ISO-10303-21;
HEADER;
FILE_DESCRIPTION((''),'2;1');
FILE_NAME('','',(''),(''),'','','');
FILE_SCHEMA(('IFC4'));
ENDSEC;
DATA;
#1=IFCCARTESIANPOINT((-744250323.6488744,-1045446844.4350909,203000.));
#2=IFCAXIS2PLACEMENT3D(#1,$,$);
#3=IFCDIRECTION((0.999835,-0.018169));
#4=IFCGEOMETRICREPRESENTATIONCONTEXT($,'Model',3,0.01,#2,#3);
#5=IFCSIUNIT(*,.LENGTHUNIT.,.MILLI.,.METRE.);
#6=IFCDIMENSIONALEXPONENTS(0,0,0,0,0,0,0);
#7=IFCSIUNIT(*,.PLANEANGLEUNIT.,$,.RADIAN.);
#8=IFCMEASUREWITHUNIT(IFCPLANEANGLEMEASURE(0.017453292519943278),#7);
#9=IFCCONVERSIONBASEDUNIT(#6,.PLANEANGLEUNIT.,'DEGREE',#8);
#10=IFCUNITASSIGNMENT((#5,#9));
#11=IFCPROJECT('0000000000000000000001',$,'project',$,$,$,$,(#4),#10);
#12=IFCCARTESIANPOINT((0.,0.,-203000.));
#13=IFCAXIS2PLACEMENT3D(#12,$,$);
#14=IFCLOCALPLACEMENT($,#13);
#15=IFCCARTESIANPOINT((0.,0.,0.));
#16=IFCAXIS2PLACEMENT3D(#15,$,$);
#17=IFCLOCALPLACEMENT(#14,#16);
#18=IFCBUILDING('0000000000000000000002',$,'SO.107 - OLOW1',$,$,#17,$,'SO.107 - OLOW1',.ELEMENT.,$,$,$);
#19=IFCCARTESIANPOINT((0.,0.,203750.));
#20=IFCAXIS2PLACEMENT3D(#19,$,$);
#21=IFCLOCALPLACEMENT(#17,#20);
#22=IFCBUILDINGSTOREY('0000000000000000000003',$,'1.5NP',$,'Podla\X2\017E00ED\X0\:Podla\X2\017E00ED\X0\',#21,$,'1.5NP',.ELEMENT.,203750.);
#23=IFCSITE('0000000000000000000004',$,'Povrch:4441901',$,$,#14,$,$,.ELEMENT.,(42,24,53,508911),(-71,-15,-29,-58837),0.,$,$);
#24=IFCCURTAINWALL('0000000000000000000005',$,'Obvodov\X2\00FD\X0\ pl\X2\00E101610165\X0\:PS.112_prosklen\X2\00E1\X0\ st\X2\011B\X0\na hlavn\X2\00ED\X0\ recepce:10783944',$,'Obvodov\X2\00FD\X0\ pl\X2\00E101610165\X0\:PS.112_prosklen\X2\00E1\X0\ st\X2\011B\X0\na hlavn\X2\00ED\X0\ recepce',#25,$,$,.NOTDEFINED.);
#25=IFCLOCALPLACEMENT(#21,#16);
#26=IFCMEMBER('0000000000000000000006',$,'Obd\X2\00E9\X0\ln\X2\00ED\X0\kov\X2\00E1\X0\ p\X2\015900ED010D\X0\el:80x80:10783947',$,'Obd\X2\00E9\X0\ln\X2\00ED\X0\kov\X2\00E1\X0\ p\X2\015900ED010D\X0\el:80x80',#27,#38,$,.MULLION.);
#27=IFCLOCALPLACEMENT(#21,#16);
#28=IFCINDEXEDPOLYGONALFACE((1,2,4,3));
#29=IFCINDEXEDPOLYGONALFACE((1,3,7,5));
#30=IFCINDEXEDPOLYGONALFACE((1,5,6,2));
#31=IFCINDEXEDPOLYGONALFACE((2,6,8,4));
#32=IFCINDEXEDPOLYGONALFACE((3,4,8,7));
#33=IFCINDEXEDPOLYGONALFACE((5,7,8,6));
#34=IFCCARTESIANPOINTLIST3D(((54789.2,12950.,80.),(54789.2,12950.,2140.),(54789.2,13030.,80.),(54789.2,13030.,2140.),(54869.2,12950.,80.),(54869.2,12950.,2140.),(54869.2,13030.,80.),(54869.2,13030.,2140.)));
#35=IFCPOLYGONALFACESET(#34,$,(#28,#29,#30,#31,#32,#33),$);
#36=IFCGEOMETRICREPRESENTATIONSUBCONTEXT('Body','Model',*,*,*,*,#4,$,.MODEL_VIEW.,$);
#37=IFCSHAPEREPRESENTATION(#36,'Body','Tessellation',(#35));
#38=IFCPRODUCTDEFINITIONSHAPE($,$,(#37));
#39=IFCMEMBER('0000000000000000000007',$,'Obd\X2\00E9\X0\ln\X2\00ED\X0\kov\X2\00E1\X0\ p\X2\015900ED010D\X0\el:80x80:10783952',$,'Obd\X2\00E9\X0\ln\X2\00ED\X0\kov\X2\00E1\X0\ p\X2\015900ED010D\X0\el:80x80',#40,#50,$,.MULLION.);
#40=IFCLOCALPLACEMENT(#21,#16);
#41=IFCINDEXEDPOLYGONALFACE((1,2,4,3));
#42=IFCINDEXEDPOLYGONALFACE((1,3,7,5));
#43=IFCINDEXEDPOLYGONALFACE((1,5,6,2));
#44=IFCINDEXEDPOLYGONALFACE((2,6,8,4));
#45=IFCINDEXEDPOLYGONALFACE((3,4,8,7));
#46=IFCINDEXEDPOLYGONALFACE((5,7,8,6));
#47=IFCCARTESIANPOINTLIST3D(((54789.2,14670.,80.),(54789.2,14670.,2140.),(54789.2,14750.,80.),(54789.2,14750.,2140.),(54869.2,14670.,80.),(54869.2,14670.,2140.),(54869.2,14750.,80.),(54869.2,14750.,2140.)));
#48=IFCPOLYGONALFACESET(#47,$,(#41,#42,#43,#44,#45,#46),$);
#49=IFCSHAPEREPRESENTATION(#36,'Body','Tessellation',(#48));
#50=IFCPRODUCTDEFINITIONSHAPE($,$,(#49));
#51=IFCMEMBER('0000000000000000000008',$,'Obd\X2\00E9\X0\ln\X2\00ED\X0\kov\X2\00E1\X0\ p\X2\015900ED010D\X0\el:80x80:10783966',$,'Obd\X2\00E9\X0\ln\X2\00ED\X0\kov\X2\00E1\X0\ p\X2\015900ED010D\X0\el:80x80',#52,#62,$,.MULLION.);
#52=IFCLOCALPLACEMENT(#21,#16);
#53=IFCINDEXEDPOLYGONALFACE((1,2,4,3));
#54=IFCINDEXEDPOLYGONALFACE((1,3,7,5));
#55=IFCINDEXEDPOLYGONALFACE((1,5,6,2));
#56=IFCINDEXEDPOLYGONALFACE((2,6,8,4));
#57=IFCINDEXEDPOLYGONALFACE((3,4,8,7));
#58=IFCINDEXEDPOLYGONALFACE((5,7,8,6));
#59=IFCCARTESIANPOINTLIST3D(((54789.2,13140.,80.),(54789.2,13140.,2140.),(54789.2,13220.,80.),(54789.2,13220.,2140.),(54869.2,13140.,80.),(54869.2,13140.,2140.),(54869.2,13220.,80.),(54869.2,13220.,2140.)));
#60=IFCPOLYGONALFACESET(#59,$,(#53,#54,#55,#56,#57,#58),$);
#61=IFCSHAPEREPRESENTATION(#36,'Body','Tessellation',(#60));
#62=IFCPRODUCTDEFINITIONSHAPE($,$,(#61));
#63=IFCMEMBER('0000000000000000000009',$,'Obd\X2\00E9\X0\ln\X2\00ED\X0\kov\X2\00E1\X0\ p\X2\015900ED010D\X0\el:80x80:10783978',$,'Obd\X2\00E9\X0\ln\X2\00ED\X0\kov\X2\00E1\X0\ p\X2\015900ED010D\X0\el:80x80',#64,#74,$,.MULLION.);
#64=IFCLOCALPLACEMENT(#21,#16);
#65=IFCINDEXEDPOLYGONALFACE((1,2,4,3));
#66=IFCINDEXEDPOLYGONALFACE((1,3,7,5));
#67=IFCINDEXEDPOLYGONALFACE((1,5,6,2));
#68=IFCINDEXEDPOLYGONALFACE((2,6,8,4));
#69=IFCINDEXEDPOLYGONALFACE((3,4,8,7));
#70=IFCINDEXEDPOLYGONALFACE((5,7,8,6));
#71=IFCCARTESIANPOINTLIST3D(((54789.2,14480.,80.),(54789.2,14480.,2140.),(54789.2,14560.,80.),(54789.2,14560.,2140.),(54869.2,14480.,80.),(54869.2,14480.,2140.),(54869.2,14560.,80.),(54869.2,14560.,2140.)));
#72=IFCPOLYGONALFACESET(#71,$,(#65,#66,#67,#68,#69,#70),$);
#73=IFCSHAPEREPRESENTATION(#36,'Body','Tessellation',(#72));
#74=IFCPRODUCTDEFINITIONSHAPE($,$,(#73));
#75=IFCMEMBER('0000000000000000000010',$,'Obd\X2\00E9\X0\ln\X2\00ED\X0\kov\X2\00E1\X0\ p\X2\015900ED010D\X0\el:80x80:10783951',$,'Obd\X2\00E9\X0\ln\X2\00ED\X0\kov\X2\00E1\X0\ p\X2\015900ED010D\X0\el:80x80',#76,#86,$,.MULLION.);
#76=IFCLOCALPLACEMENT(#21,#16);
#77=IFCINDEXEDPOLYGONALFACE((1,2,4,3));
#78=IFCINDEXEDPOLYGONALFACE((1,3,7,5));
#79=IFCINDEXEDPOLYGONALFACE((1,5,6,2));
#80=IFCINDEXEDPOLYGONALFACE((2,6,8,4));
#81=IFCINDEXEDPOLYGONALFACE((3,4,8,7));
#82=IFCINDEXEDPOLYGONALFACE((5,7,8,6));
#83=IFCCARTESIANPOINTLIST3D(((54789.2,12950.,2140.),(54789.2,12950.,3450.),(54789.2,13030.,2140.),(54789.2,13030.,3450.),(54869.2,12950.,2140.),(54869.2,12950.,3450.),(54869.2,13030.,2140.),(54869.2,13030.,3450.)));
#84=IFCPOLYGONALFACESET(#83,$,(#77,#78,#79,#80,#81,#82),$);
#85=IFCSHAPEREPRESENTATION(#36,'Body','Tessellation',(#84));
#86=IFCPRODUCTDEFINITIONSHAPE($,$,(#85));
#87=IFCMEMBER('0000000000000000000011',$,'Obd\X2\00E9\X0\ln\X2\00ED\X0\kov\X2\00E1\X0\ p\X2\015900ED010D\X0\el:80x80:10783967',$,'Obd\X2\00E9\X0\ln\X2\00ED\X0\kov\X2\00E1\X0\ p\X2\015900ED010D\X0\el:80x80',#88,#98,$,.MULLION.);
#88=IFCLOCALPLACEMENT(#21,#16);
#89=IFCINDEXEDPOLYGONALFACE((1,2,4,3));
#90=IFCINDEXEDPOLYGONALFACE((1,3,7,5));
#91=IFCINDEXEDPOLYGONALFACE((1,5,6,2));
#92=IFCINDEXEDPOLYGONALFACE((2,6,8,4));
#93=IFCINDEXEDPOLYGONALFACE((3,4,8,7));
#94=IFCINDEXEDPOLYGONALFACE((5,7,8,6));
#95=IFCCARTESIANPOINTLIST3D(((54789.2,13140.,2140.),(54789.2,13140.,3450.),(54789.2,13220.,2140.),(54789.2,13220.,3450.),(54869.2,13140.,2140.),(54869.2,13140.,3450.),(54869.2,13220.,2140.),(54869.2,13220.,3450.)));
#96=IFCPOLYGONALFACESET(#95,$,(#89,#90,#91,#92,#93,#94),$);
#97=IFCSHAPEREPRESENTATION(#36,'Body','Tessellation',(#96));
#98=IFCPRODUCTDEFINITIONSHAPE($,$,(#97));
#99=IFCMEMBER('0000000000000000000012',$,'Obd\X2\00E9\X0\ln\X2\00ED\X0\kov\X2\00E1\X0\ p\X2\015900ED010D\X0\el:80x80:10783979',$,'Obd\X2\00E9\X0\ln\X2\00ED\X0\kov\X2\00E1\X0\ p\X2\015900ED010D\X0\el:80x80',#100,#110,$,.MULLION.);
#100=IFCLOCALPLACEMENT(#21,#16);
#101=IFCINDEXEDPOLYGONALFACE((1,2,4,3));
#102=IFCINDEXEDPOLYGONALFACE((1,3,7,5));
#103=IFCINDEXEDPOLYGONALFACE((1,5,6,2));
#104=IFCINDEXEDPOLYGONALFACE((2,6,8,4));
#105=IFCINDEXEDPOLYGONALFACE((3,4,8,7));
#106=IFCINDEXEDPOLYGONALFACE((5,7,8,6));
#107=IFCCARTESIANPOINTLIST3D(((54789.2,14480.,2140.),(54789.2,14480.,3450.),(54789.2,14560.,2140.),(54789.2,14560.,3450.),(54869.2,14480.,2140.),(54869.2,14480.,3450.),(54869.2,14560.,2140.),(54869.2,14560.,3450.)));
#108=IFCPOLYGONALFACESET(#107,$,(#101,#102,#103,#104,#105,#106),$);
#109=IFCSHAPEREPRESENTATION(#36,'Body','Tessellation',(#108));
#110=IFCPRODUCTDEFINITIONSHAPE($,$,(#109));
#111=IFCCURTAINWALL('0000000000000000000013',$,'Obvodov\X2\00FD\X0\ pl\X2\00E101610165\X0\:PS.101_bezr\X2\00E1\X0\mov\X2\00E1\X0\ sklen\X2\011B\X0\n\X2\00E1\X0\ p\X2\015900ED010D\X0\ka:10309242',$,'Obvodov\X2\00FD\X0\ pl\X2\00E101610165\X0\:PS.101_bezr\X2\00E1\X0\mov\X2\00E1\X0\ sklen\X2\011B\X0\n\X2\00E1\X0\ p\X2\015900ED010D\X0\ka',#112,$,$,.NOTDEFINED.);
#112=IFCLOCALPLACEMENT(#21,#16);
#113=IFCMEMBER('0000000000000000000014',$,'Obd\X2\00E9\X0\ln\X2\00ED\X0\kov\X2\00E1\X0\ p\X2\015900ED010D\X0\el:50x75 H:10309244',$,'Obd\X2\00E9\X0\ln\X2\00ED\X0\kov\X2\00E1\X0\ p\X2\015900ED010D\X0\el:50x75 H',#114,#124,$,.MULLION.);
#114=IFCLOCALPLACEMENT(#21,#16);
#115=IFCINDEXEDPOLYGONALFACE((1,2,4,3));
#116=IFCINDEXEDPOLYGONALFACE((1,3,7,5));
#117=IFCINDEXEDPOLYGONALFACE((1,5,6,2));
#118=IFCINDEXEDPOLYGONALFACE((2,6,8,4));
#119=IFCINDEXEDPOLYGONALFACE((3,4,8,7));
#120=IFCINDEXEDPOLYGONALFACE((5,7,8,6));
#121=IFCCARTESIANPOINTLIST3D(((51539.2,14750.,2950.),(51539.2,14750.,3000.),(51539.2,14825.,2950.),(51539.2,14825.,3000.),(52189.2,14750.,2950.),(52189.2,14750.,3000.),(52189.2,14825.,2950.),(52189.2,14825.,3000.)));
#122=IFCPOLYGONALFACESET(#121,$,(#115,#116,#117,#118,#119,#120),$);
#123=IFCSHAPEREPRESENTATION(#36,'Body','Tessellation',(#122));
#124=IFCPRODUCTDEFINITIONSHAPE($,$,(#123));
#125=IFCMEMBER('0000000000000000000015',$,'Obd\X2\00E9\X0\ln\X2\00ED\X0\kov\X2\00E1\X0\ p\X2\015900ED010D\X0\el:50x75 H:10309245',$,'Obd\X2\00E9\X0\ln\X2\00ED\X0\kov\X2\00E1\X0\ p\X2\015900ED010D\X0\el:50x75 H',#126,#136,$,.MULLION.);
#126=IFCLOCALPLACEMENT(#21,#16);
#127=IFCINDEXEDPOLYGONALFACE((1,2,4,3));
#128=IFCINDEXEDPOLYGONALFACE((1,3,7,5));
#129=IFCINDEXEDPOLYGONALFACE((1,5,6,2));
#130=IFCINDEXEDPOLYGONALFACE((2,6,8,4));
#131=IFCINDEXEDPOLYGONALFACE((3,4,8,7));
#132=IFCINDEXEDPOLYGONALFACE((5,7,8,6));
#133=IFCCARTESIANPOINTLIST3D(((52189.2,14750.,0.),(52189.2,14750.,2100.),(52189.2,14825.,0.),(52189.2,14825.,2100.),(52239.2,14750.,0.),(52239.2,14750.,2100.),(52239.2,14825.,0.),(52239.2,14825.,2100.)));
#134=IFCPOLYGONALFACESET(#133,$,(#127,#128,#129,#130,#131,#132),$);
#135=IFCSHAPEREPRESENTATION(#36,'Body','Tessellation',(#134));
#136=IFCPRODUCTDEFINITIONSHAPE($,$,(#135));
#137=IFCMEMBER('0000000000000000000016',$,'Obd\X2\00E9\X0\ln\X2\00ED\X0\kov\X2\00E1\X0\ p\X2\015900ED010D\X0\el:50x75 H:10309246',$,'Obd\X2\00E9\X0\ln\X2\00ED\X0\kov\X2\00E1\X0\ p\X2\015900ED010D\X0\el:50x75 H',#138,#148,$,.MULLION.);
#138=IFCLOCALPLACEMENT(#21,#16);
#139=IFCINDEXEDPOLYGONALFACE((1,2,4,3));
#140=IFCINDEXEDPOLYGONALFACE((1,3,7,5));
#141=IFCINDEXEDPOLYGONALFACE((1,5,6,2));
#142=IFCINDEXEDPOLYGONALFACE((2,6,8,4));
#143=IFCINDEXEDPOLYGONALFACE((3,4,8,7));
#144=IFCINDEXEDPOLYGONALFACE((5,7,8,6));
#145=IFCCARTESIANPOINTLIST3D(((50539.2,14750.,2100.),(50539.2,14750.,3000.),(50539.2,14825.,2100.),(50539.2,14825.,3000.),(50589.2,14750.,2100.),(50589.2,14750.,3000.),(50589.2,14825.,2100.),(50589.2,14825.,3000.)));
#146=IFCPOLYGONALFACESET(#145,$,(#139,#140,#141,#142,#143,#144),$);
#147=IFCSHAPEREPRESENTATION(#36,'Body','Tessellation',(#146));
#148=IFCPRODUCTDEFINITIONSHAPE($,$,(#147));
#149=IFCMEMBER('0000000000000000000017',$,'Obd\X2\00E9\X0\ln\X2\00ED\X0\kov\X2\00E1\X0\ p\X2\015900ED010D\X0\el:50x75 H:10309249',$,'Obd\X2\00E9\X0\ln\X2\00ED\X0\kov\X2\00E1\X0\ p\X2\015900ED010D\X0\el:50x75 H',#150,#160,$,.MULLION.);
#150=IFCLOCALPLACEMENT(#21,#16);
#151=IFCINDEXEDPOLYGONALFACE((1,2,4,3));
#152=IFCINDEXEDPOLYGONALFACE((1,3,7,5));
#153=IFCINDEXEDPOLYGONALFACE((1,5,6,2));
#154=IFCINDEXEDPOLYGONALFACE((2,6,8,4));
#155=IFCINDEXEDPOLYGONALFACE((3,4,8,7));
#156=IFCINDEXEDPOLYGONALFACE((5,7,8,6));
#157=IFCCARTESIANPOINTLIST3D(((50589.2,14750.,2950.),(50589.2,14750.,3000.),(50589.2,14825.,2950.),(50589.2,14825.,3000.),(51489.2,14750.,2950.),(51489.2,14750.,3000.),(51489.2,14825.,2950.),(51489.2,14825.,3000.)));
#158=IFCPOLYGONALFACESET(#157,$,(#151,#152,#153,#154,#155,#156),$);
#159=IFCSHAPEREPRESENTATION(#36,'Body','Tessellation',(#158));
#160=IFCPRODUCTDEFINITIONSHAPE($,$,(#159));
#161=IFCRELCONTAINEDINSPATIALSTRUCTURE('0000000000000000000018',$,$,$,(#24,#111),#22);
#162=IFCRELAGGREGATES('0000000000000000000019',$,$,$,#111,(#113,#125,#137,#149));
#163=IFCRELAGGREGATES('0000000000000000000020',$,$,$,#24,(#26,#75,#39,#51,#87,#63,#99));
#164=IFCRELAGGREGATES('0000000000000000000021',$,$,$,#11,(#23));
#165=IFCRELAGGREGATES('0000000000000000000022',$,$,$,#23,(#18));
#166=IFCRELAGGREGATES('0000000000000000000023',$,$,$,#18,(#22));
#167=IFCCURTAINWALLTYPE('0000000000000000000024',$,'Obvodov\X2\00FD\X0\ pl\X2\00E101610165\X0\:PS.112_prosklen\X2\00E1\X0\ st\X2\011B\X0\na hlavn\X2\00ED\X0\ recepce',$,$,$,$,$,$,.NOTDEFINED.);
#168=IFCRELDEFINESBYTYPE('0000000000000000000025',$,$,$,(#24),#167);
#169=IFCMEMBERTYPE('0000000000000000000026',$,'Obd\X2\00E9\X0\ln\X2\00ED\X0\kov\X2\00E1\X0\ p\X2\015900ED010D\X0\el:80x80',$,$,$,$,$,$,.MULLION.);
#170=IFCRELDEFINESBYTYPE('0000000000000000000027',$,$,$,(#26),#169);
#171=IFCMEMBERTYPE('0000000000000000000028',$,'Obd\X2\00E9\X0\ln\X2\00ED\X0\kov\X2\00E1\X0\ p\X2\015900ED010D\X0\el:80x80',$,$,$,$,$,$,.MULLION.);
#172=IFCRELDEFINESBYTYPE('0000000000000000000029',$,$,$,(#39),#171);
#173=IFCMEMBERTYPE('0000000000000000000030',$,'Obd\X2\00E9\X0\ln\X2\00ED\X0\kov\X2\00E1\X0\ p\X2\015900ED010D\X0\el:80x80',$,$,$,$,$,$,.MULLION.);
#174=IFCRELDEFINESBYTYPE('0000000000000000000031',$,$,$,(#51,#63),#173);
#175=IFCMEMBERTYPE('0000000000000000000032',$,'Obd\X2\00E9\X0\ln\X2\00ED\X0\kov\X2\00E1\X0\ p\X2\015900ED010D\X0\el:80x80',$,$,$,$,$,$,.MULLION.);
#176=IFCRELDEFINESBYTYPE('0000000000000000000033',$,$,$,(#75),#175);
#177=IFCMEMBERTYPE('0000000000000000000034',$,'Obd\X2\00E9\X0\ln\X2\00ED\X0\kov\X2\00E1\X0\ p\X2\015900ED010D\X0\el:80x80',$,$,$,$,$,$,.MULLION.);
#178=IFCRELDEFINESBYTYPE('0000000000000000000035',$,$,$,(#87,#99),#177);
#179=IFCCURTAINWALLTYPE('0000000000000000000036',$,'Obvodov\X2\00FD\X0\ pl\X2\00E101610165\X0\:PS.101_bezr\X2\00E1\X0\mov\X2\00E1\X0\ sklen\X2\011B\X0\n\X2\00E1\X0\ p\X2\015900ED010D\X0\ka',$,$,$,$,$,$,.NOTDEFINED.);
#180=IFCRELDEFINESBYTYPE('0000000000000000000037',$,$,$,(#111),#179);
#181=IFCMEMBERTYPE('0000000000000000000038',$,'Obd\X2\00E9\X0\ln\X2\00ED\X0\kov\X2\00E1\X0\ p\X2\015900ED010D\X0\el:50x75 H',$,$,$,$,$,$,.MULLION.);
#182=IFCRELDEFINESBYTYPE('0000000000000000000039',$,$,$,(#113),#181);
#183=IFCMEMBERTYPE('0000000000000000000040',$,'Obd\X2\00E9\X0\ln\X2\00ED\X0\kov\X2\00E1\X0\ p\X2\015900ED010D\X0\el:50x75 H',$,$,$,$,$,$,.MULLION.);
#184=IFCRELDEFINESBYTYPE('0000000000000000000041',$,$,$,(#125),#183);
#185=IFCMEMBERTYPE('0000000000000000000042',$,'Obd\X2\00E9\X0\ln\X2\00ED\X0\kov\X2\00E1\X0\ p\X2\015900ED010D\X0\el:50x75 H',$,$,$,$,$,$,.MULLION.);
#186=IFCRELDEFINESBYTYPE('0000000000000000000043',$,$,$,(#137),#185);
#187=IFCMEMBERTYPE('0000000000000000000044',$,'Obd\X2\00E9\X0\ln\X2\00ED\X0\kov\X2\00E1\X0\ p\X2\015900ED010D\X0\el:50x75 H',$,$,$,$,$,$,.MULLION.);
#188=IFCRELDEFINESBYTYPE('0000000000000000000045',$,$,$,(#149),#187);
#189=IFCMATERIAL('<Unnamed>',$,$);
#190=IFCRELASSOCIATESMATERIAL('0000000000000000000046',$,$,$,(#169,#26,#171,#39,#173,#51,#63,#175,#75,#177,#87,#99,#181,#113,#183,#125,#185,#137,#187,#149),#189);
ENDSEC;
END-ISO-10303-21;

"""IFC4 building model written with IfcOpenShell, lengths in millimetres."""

from ifc_helpers import new_model, entity, si_unit, converted_unit, direction, frame, origin, place, context, subcontext, project, spatial, indexed_curve, outline, extrude, source, transform, mapped, material, type_object, type_shapes, element, aggregate, save


model = new_model("IFC4")

# Units and contexts
model_context = context("Model", 3, precision=0.01, world=frame((-744250323.6488744, -1045446844.4350909, 203000.0)), true_north=direction((0.999835, -0.018169)))
body_context = subcontext(model_context, "Body", "Model", "MODEL_VIEW")
ifc_project = project(units=[si_unit("LENGTHUNIT", "METRE", prefix="MILLI"), converted_unit("PLANEANGLEUNIT", "DEGREE", entity("IfcPlaneAngleMeasure", 0.017453292519943278), si_unit("PLANEANGLEUNIT", "RADIAN"), dimensions=[0, 0, 0, 0, 0, 0, 0])], contexts=[model_context])

# Site, building, storey
site_placement = place(None, frame((0.0, 0.0, -203000.0)))
site = spatial("IfcSite", under=ifc_project, at=site_placement, Name="Povrch:4441901", CompositionType="ELEMENT", RefLatitude=(42, 24, 53, 508911), RefLongitude=(-71, -15, -29, -58837), RefElevation=0.0)
building_placement = place(site_placement, origin())
building = spatial("IfcBuilding", under=site, at=building_placement, Name="SO.107 - OLOW1", LongName="SO.107 - OLOW1", CompositionType="ELEMENT")
storey_placement = place(building_placement, frame((0.0, 0.0, 203750.0)))
storey = spatial("IfcBuildingStorey", under=building, at=storey_placement, Name="1.5NP", ObjectType="Podlaží:Podlaží", LongName="1.5NP", CompositionType="ELEMENT", Elevation=203750.0)

# Curtain walls, members
curtain_wall_type_1 = type_object("IfcCurtainWallType", Name="Obvodový plášť:PS.112_prosklená stěna hlavní recepce", PredefinedType="NOTDEFINED")
curtain_wall_1_placement = place(storey_placement, frame((0.0, 0.0, -203750.0)))
curtain_wall_1 = element("IfcCurtainWall", 1, at=curtain_wall_1_placement, inside=storey, type_object=curtain_wall_type_1, Name="Obvodový plášť:PS.112_prosklená stěna hlavní recepce:10783944", ObjectType="Obvodový plášť:PS.112_prosklená stěna hlavní recepce", PredefinedType="NOTDEFINED")
ifc_material_1 = material(Name="<Unnamed>")
member_type_1 = type_object("IfcMemberType", Name="Obdélníková příčel:80x80", PredefinedType="MULLION", material=ifc_material_1)
shared_shape_1 = source(origin(), body_context, "Body", "SweptSolid", [
    extrude(outline(indexed_curve([(-40.0, -40.0), (40.0, -40.0), (40.0, 40.0), (-40.0, 40.0), (-40.0, -40.0)], self_intersect=False)), frame((-40.0, 0.0, -2060.0), z_axis=(0.0, 0.0, 1.0), x_axis=(-1.0, 0.0, 0.0)), (0.0, 0.0, 1.0), 2060.0),
])
type_shapes(member_type_1, [shared_shape_1])
member_1_placement = place(curtain_wall_1_placement, frame((54829.2, 12950.0, 203830.0), z_axis=(0.0, 0.0, -1.0), x_axis=(0.0, -1.0, 0.0)))
member_1 = element("IfcMember", 2, at=member_1_placement, type_object=member_type_1, material=ifc_material_1, Name="Obdélníková příčel:80x80:10783947", ObjectType="Obdélníková příčel:80x80", PredefinedType="MULLION", context=body_context, shape_type="MappedRepresentation", body=[
    mapped(shared_shape_1, transform((0.0, 0.0, 0.0), scale=1.0)),
])
member_type_2 = type_object("IfcMemberType", Name="Obdélníková příčel:80x80", PredefinedType="MULLION", material=ifc_material_1)
shared_shape_2 = source(origin(), body_context, "Body", "SweptSolid", [
    extrude(outline(indexed_curve([(-40.0, -40.0), (40.0, -40.0), (40.0, 40.0), (-40.0, 40.0), (-40.0, -40.0)], self_intersect=False)), frame((-40.0, 0.0, -2060.0), z_axis=(0.0, 0.0, 1.0), x_axis=(-1.0, 0.0, 0.0)), (0.0, 0.0, 1.0), 2060.0),
])
type_shapes(member_type_2, [shared_shape_2])
member_2_placement = place(curtain_wall_1_placement, frame((54829.2, 14750.0, 205890.0), z_axis=(0.0, 0.0, 1.0), x_axis=(0.0, 1.0, 0.0)))
member_2 = element("IfcMember", 3, at=member_2_placement, type_object=member_type_2, material=ifc_material_1, Name="Obdélníková příčel:80x80:10783952", ObjectType="Obdélníková příčel:80x80", PredefinedType="MULLION", context=body_context, shape_type="MappedRepresentation", body=[
    mapped(shared_shape_2, transform((0.0, 0.0, 0.0), scale=1.0)),
])
member_type_3 = type_object("IfcMemberType", Name="Obdélníková příčel:80x80", PredefinedType="MULLION", material=ifc_material_1)
shared_shape_3 = source(origin(), body_context, "Body", "SweptSolid", [
    extrude(outline(indexed_curve([(-40.0, -40.0), (40.0, -40.0), (40.0, 40.0), (-40.0, 40.0), (-40.0, -40.0)], self_intersect=False)), frame((0.0, 0.0, -2060.0), z_axis=(0.0, 0.0, 1.0), x_axis=(-1.0, 0.0, 0.0)), (0.0, 0.0, 1.0), 2060.0),
])
type_shapes(member_type_3, [shared_shape_3])
member_3_placement = place(curtain_wall_1_placement, frame((54829.2, 13180.0, 203830.0), z_axis=(0.0, 0.0, -1.0), x_axis=(0.0, -1.0, 0.0)))
member_3 = element("IfcMember", 4, at=member_3_placement, type_object=member_type_3, material=ifc_material_1, Name="Obdélníková příčel:80x80:10783966", ObjectType="Obdélníková příčel:80x80", PredefinedType="MULLION", context=body_context, shape_type="MappedRepresentation", body=[
    mapped(shared_shape_3, transform((0.0, 0.0, 0.0), scale=1.0)),
])
member_4_placement = place(curtain_wall_1_placement, frame((54829.2, 14520.0, 203830.0), z_axis=(0.0, 0.0, -1.0), x_axis=(0.0, -1.0, 0.0)))
member_4 = element("IfcMember", 5, at=member_4_placement, type_object=member_type_3, material=ifc_material_1, Name="Obdélníková příčel:80x80:10783978", ObjectType="Obdélníková příčel:80x80", PredefinedType="MULLION", context=body_context, shape_type="MappedRepresentation", body=[
    mapped(shared_shape_3, transform((0.0, 0.0, 0.0), scale=1.0)),
])
member_type_4 = type_object("IfcMemberType", Name="Obdélníková příčel:80x80", PredefinedType="MULLION", material=ifc_material_1)
shared_shape_4 = source(origin(), body_context, "Body", "SweptSolid", [
    extrude(outline(indexed_curve([(-40.0, -40.0), (40.0, -40.0), (40.0, 40.0), (-40.0, 40.0), (-40.0, -40.0)], self_intersect=False)), frame((-40.0, 0.0, -1310.0), z_axis=(0.0, 0.0, 1.0), x_axis=(-1.0, 0.0, 0.0)), (0.0, 0.0, 1.0), 1310.0),
])
type_shapes(member_type_4, [shared_shape_4])
member_5_placement = place(curtain_wall_1_placement, frame((54829.2, 12950.0, 205890.0), z_axis=(0.0, 0.0, -1.0), x_axis=(0.0, -1.0, 0.0)))
member_5 = element("IfcMember", 6, at=member_5_placement, type_object=member_type_4, material=ifc_material_1, Name="Obdélníková příčel:80x80:10783951", ObjectType="Obdélníková příčel:80x80", PredefinedType="MULLION", context=body_context, shape_type="MappedRepresentation", body=[
    mapped(shared_shape_4, transform((0.0, 0.0, 0.0), scale=1.0)),
])
member_type_5 = type_object("IfcMemberType", Name="Obdélníková příčel:80x80", PredefinedType="MULLION", material=ifc_material_1)
shared_shape_5 = source(origin(), body_context, "Body", "SweptSolid", [
    extrude(outline(indexed_curve([(-40.0, -40.0), (40.0, -40.0), (40.0, 40.0), (-40.0, 40.0), (-40.0, -40.0)], self_intersect=False)), frame((0.0, 0.0, -1310.0), z_axis=(0.0, 0.0, 1.0), x_axis=(-1.0, 0.0, 0.0)), (0.0, 0.0, 1.0), 1310.0),
])
type_shapes(member_type_5, [shared_shape_5])
member_6_placement = place(curtain_wall_1_placement, frame((54829.2, 13180.0, 205890.0), z_axis=(0.0, 0.0, -1.0), x_axis=(0.0, -1.0, 0.0)))
member_6 = element("IfcMember", 7, at=member_6_placement, type_object=member_type_5, material=ifc_material_1, Name="Obdélníková příčel:80x80:10783967", ObjectType="Obdélníková příčel:80x80", PredefinedType="MULLION", context=body_context, shape_type="MappedRepresentation", body=[
    mapped(shared_shape_5, transform((0.0, 0.0, 0.0), scale=1.0)),
])
member_7_placement = place(curtain_wall_1_placement, frame((54829.2, 14520.0, 205890.0), z_axis=(0.0, 0.0, -1.0), x_axis=(0.0, -1.0, 0.0)))
member_7 = element("IfcMember", 8, at=member_7_placement, type_object=member_type_5, material=ifc_material_1, Name="Obdélníková příčel:80x80:10783979", ObjectType="Obdélníková příčel:80x80", PredefinedType="MULLION", context=body_context, shape_type="MappedRepresentation", body=[
    mapped(shared_shape_5, transform((0.0, 0.0, 0.0), scale=1.0)),
])
curtain_wall_type_2 = type_object("IfcCurtainWallType", Name="Obvodový plášť:PS.101_bezrámová skleněná příčka", PredefinedType="NOTDEFINED")
curtain_wall_2_placement = place(storey_placement, frame((0.0, 0.0, -203750.0)))
curtain_wall_2 = element("IfcCurtainWall", 9, at=curtain_wall_2_placement, inside=storey, type_object=curtain_wall_type_2, Name="Obvodový plášť:PS.101_bezrámová skleněná příčka:10309242", ObjectType="Obvodový plášť:PS.101_bezrámová skleněná příčka", PredefinedType="NOTDEFINED")
member_type_6 = type_object("IfcMemberType", Name="Obdélníková příčel:50x75 H", PredefinedType="MULLION", material=ifc_material_1)
shared_shape_6 = source(origin(), body_context, "Body", "SweptSolid", [
    extrude(outline(indexed_curve([(-25.0, -37.5), (25.0, -37.5), (25.0, 37.5), (-25.0, 37.5), (-25.0, -37.5)], self_intersect=False)), frame((-25.0, -37.5, -650.0), z_axis=(0.0, 0.0, 1.0), x_axis=(-1.0, 0.0, 0.0)), (0.0, 0.0, 1.0), 650.0),
])
type_shapes(member_type_6, [shared_shape_6])
member_8_placement = place(curtain_wall_2_placement, frame((52189.2, 14750.0, 206750.0), z_axis=(1.0, 0.0, 0.0), x_axis=(0.0, 0.0, 1.0)))
member_8 = element("IfcMember", 10, at=member_8_placement, type_object=member_type_6, material=ifc_material_1, Name="Obdélníková příčel:50x75 H:10309244", ObjectType="Obdélníková příčel:50x75 H", PredefinedType="MULLION", context=body_context, shape_type="MappedRepresentation", body=[
    mapped(shared_shape_6, transform((0.0, 0.0, 0.0), scale=1.0)),
])
member_type_7 = type_object("IfcMemberType", Name="Obdélníková příčel:50x75 H", PredefinedType="MULLION", material=ifc_material_1)
shared_shape_7 = source(origin(), body_context, "Body", "SweptSolid", [
    extrude(outline(indexed_curve([(-25.0, -37.5), (25.0, -37.5), (25.0, 37.5), (-25.0, 37.5), (-25.0, -37.5)], self_intersect=False)), frame((-25.0, -37.5, -2100.0), z_axis=(0.0, 0.0, 1.0), x_axis=(-1.0, 0.0, 0.0)), (0.0, 0.0, 1.0), 2100.0),
])
type_shapes(member_type_7, [shared_shape_7])
member_9_placement = place(curtain_wall_2_placement, frame((52239.2, 14750.0, 203750.0), z_axis=(0.0, 0.0, -1.0), x_axis=(1.0, 0.0, 0.0)))
member_9 = element("IfcMember", 11, at=member_9_placement, type_object=member_type_7, material=ifc_material_1, Name="Obdélníková příčel:50x75 H:10309245", ObjectType="Obdélníková příčel:50x75 H", PredefinedType="MULLION", context=body_context, shape_type="MappedRepresentation", body=[
    mapped(shared_shape_7, transform((0.0, 0.0, 0.0), scale=1.0)),
])
member_type_8 = type_object("IfcMemberType", Name="Obdélníková příčel:50x75 H", PredefinedType="MULLION", material=ifc_material_1)
shared_shape_8 = source(origin(), body_context, "Body", "SweptSolid", [
    extrude(outline(indexed_curve([(-25.0, -37.5), (25.0, -37.5), (25.0, 37.5), (-25.0, 37.5), (-25.0, -37.5)], self_intersect=False)), frame((-25.0, -37.5, -900.0), z_axis=(0.0, 0.0, 1.0), x_axis=(-1.0, 0.0, 0.0)), (0.0, 0.0, 1.0), 900.0),
])
type_shapes(member_type_8, [shared_shape_8])
member_10_placement = place(curtain_wall_2_placement, frame((50539.2, 14750.0, 206750.0), z_axis=(0.0, 0.0, 1.0), x_axis=(-1.0, 0.0, 0.0)))
member_10 = element("IfcMember", 12, at=member_10_placement, type_object=member_type_8, material=ifc_material_1, Name="Obdélníková příčel:50x75 H:10309246", ObjectType="Obdélníková příčel:50x75 H", PredefinedType="MULLION", context=body_context, shape_type="MappedRepresentation", body=[
    mapped(shared_shape_8, transform((0.0, 0.0, 0.0), scale=1.0)),
])
member_type_9 = type_object("IfcMemberType", Name="Obdélníková příčel:50x75 H", PredefinedType="MULLION", material=ifc_material_1)
shared_shape_9 = source(origin(), body_context, "Body", "SweptSolid", [
    extrude(outline(indexed_curve([(-25.0, -37.5), (25.0, -37.5), (25.0, 37.5), (-25.0, 37.5), (-25.0, -37.5)], self_intersect=False)), frame((-25.0, -37.5, -900.0), z_axis=(0.0, 0.0, 1.0), x_axis=(-1.0, 0.0, 0.0)), (0.0, 0.0, 1.0), 900.0),
])
type_shapes(member_type_9, [shared_shape_9])
member_11_placement = place(curtain_wall_2_placement, frame((51489.2, 14750.0, 206750.0), z_axis=(1.0, 0.0, 0.0), x_axis=(0.0, 0.0, 1.0)))
member_11 = element("IfcMember", 13, at=member_11_placement, type_object=member_type_9, material=ifc_material_1, Name="Obdélníková příčel:50x75 H:10309249", ObjectType="Obdélníková příčel:50x75 H", PredefinedType="MULLION", context=body_context, shape_type="MappedRepresentation", body=[
    mapped(shared_shape_9, transform((0.0, 0.0, 0.0), scale=1.0)),
])

aggregate(curtain_wall_2, [member_8, member_9, member_10, member_11])
aggregate(curtain_wall_1, [member_1, member_5, member_2, member_3, member_6, member_4, member_7])

save(model, "model.ifc")
